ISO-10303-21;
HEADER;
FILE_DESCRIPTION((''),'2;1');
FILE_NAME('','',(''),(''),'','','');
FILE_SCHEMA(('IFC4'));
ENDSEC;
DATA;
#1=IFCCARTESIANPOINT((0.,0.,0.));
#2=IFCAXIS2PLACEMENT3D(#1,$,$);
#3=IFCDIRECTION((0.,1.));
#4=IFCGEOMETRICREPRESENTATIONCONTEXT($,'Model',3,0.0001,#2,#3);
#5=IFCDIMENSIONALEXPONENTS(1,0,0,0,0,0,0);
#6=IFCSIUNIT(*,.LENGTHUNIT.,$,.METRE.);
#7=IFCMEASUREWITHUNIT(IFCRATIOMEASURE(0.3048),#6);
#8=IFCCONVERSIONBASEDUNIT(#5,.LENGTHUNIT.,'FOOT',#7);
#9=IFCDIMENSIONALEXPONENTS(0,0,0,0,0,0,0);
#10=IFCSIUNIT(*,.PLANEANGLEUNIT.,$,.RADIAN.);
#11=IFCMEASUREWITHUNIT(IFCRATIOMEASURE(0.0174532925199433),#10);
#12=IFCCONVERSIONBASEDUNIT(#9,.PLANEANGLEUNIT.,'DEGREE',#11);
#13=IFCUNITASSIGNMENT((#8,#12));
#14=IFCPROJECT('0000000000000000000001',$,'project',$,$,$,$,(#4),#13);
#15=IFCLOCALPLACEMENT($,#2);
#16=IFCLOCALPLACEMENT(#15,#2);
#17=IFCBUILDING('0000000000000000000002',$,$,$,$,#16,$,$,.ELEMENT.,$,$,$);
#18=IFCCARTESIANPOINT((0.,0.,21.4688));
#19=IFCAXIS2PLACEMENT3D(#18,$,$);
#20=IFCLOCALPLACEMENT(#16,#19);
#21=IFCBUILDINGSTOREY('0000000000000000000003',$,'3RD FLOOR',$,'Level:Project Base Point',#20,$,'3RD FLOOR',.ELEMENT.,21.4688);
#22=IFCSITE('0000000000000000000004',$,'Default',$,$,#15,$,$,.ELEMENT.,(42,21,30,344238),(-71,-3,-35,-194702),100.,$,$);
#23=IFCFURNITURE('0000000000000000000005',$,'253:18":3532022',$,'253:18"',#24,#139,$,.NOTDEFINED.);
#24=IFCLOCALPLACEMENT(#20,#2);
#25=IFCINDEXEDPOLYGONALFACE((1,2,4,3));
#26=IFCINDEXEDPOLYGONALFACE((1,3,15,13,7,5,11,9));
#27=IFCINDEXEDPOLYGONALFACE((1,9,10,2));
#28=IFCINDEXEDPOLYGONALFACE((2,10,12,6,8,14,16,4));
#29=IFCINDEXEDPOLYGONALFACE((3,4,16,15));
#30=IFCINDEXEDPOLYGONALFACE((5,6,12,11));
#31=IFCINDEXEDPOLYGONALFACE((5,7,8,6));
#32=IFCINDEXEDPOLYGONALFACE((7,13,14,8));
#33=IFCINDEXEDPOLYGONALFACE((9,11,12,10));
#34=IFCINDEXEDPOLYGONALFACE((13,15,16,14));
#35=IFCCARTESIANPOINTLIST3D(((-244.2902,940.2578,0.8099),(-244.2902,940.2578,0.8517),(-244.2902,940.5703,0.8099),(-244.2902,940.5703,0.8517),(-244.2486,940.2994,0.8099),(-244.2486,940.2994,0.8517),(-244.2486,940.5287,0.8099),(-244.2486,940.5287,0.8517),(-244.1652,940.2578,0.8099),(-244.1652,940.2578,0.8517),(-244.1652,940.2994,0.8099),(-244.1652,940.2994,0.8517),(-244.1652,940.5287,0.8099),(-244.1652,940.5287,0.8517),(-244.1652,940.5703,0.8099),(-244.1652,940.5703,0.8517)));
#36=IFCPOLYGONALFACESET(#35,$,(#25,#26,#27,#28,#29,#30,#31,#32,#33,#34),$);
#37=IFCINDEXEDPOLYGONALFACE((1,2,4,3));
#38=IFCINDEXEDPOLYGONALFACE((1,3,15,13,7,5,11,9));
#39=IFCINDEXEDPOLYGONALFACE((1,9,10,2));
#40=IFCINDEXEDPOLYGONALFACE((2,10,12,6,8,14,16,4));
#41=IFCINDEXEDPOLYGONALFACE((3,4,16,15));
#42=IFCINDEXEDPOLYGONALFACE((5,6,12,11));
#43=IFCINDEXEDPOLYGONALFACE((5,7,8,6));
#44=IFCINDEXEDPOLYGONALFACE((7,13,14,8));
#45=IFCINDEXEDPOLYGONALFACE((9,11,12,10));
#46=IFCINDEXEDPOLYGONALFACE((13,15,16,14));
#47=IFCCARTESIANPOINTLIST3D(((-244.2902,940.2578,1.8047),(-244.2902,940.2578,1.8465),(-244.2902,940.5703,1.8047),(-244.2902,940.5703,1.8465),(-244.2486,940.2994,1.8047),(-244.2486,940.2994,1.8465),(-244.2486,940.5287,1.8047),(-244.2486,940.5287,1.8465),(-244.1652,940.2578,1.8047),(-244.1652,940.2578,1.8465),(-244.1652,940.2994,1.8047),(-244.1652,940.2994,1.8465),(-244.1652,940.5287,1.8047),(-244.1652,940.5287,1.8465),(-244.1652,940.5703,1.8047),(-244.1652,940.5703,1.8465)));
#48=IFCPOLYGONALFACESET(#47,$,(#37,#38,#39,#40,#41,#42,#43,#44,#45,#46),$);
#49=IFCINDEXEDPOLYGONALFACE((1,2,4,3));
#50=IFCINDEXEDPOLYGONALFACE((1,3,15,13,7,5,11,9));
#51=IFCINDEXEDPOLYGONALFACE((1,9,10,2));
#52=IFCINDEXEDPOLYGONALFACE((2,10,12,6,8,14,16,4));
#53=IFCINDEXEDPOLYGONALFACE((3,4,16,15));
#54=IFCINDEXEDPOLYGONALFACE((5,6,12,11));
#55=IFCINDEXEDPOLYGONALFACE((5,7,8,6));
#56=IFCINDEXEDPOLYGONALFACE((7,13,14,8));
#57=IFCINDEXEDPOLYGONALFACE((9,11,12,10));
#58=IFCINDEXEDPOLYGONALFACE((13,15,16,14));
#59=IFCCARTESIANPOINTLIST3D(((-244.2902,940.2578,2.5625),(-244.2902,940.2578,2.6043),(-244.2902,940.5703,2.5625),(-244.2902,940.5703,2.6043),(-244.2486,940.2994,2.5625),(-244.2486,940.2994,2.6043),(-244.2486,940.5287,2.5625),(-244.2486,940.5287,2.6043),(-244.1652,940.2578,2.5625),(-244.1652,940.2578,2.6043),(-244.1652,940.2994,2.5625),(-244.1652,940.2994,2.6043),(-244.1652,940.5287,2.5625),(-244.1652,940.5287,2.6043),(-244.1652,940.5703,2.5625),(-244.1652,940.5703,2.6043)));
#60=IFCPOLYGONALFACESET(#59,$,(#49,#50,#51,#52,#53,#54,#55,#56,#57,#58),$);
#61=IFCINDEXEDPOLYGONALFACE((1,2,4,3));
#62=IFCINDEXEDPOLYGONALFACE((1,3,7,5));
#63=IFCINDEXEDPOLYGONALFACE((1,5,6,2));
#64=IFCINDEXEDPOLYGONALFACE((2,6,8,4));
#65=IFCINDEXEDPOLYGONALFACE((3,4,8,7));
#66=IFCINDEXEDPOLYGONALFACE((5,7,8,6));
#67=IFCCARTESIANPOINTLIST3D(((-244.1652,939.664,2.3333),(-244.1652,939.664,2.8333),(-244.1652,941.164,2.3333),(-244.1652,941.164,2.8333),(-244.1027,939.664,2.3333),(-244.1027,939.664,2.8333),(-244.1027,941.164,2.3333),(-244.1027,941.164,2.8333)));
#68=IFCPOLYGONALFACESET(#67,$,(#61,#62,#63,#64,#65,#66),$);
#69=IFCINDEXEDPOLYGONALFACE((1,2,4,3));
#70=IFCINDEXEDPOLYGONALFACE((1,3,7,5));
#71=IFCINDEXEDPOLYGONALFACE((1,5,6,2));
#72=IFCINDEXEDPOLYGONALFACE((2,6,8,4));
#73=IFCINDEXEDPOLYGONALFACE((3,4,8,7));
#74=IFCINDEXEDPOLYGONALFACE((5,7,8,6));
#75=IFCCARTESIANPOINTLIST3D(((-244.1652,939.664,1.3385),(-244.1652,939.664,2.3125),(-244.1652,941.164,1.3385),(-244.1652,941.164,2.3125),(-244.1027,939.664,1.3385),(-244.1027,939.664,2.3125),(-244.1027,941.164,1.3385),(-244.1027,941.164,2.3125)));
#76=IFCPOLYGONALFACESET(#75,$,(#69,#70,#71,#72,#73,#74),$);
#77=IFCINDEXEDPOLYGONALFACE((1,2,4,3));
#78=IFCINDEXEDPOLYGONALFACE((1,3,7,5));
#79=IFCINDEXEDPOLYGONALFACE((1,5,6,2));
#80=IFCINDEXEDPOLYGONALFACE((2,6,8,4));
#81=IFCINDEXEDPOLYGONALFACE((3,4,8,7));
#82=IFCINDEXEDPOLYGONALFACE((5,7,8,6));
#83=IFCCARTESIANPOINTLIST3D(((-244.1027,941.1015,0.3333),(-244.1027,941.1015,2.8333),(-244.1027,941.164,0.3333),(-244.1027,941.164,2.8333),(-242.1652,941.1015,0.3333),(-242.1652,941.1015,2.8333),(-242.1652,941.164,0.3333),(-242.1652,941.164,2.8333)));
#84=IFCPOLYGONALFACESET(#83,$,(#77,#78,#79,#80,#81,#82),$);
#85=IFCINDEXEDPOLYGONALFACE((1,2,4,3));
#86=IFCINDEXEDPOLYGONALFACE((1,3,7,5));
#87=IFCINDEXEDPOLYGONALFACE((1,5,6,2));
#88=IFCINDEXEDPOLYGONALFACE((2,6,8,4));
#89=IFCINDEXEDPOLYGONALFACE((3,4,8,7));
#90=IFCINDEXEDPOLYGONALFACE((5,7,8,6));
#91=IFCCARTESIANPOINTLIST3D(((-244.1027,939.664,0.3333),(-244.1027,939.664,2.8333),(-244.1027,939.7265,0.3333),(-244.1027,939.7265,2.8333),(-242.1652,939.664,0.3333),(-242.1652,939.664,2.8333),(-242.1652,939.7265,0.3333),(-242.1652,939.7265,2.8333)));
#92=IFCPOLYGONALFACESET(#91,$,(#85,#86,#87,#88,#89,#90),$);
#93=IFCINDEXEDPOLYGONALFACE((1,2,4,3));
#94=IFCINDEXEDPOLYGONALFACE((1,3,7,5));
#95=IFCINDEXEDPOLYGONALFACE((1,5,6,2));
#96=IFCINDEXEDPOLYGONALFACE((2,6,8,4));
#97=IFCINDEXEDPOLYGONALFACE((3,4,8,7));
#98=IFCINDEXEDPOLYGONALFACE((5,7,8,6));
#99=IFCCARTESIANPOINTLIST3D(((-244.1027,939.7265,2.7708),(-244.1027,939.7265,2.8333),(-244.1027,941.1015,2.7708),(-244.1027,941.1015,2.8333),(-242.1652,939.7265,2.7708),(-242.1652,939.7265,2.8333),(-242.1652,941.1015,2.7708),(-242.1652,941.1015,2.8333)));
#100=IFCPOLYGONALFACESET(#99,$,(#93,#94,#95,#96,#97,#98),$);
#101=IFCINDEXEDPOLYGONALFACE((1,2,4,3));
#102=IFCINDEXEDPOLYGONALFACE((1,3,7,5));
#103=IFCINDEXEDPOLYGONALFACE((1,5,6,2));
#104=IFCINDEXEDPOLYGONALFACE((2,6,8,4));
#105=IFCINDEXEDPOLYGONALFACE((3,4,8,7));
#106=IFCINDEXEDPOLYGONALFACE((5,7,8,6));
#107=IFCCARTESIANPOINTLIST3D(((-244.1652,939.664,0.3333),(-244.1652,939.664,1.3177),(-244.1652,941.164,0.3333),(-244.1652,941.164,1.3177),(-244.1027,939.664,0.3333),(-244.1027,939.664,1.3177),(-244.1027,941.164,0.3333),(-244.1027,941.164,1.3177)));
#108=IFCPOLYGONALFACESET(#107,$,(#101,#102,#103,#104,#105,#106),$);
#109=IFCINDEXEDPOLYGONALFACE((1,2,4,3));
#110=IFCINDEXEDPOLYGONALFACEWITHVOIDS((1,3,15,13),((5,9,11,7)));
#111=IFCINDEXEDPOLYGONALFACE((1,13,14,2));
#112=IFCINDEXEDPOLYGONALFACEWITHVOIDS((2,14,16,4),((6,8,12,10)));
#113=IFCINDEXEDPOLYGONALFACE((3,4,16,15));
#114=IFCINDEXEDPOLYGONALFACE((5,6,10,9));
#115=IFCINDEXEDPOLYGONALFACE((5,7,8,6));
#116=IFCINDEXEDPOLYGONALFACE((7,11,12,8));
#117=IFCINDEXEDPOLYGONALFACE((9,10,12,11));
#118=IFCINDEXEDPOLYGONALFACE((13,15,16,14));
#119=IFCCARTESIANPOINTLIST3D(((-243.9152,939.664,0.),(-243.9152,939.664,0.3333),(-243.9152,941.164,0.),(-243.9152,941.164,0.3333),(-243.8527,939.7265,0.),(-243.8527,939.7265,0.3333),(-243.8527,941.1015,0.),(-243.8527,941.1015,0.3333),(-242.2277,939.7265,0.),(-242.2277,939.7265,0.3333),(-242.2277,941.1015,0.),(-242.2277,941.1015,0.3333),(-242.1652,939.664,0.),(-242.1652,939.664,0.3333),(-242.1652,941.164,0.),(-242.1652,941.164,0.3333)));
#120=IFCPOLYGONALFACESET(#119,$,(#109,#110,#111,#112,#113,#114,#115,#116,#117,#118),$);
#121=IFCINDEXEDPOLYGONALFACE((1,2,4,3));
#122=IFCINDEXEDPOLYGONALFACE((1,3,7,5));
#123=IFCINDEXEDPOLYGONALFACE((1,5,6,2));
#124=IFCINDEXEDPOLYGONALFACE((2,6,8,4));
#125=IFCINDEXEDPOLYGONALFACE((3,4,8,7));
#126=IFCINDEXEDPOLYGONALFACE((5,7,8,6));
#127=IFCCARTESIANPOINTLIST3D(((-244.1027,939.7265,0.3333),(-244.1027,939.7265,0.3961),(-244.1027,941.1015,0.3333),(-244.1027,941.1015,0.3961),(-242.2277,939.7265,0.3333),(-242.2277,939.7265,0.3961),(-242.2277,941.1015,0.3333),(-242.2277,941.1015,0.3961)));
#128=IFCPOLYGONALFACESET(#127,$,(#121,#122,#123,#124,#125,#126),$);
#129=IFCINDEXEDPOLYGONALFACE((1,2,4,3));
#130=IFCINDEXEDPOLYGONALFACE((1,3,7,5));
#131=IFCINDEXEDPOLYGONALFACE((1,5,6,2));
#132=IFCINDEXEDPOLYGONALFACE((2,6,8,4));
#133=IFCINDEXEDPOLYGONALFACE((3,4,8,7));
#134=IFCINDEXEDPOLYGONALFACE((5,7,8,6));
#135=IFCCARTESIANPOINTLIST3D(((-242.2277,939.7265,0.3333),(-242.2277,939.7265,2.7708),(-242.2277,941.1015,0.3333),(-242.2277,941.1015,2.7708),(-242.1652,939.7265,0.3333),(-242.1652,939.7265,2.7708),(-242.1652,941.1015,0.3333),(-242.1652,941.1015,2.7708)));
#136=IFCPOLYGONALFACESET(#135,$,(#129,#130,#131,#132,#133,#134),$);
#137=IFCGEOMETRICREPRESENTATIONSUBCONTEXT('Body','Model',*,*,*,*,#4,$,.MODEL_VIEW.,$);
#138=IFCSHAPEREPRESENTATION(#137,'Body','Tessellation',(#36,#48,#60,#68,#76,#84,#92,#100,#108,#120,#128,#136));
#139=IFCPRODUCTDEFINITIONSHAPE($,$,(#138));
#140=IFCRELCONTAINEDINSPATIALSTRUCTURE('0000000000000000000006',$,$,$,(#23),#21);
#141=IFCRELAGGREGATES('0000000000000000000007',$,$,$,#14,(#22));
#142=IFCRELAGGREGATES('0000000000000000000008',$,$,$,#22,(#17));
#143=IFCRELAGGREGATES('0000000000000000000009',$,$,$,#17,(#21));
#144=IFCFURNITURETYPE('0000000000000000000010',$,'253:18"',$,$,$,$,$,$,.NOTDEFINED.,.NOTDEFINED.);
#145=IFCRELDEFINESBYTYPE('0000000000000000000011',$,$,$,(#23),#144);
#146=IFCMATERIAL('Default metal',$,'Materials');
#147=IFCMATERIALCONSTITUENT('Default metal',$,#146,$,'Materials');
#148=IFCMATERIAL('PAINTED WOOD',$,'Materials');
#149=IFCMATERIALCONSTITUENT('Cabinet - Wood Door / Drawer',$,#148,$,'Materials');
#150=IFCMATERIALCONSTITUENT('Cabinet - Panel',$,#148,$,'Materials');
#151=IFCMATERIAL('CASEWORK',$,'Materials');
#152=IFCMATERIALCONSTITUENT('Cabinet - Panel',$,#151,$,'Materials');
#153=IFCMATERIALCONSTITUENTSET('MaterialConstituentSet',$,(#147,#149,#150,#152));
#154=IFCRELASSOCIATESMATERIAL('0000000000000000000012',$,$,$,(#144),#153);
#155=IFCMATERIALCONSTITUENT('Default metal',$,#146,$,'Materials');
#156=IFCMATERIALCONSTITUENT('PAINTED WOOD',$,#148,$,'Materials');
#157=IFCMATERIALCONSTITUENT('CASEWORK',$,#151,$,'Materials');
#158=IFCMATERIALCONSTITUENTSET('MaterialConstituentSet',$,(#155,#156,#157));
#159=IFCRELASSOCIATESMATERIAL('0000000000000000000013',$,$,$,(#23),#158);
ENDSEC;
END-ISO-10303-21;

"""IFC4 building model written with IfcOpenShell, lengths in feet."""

from ifc_helpers import new_model, entity, si_unit, converted_unit, direction, frame, frame_2d, origin, origin_2d_with_axis, place, context, subcontext, project, spatial, polyline, rectangle, outline, extrude, source, transform, mapped, material, constituent, constituent_set, type_object, type_shapes, element, save


model = new_model("IFC4")

# Units and contexts
model_context = context("Model", 3, precision=0.0001, world=origin(), true_north=direction((0.0, 1.0)))
body_context = subcontext(model_context, "Body", "Model", "MODEL_VIEW")
ifc_project = project(units=[converted_unit("LENGTHUNIT", "FOOT", entity("IfcRatioMeasure", 0.3048), si_unit("LENGTHUNIT", "METRE"), dimensions=[1, 0, 0, 0, 0, 0, 0]), converted_unit("PLANEANGLEUNIT", "DEGREE", entity("IfcRatioMeasure", 0.0174532925199433), si_unit("PLANEANGLEUNIT", "RADIAN"), dimensions=[0, 0, 0, 0, 0, 0, 0])], contexts=[model_context])

# Site, building, storey
site_placement = place(None, origin())
site = spatial("IfcSite", under=ifc_project, at=site_placement, Name="Default", CompositionType="ELEMENT", RefLatitude=(42, 21, 30, 344238), RefLongitude=(-71, -3, -35, -194702), RefElevation=100.0)
building_placement = place(site_placement, origin())
building = spatial("IfcBuilding", under=site, at=building_placement, CompositionType="ELEMENT")
storey_placement = place(building_placement, frame((0.0, 0.0, 21.4688)))
storey = spatial("IfcBuildingStorey", under=building, at=storey_placement, Name="3RD FLOOR", ObjectType="Level:Project Base Point", LongName="3RD FLOOR", CompositionType="ELEMENT", Elevation=21.4688)

# Furniture
ifc_material_1 = material(Name="CASEWORK", Category="Materials")
ifc_material_2 = material(Name="PAINTED WOOD", Category="Materials")
ifc_material_3 = material(Name="Default metal", Category="Materials")
ifc_constituent_1 = constituent(ifc_material_3, Name="Default metal", Category="Materials")
ifc_constituent_2 = constituent(ifc_material_2, Name="PAINTED WOOD", Category="Materials")
ifc_constituent_3 = constituent(ifc_material_1, Name="CASEWORK", Category="Materials")
ifc_constituent_set_1 = constituent_set(constituents=[ifc_constituent_1, ifc_constituent_2, ifc_constituent_3], Name="MaterialConstituentSet")
ifc_constituent_4 = constituent(ifc_material_3, Name="Default metal", Category="Materials")
ifc_constituent_5 = constituent(ifc_material_2, Name="Cabinet - Wood Door / Drawer", Category="Materials")
ifc_constituent_6 = constituent(ifc_material_2, Name="Cabinet - Panel", Category="Materials")
ifc_constituent_7 = constituent(ifc_material_1, Name="Cabinet - Panel", Category="Materials")
ifc_constituent_set_2 = constituent_set(constituents=[ifc_constituent_4, ifc_constituent_5, ifc_constituent_6, ifc_constituent_7], Name="MaterialConstituentSet")
furniture_type_1 = type_object("IfcFurnitureType", Name="253:18\"", AssemblyPlace="NOTDEFINED", PredefinedType="NOTDEFINED", material=ifc_constituent_set_2)
shared_shape_1 = source(origin(), body_context, "Body", "SweptSolid", [
    extrude(outline(polyline([(-0.0521, -0.1562), (0.0729, -0.1562), (0.0729, 0.1562), (-0.0521, 0.1562), (-0.0521, 0.1146), (0.0313, 0.1146), (0.0313, -0.1146), (-0.0521, -0.1146), (-0.0521, -0.1562)])), frame((0.0615, -2.0521, 0.8099), z_axis=(0.0, 0.0, 1.0), x_axis=(0.0, -1.0, 0.0)), (0.0, 0.0, 1.0), 0.0418),
    extrude(outline(polyline([(-0.0521, -0.1562), (0.0729, -0.1562), (0.0729, 0.1562), (-0.0521, 0.1562), (-0.0521, 0.1146), (0.0313, 0.1146), (0.0313, -0.1146), (-0.0521, -0.1146), (-0.0521, -0.1562)])), frame((0.0615, -2.0521, 1.8047), z_axis=(0.0, 0.0, 1.0), x_axis=(0.0, -1.0, 0.0)), (0.0, 0.0, 1.0), 0.0418),
    extrude(outline(polyline([(-0.0521, -0.1562), (0.0729, -0.1562), (0.0729, 0.1562), (-0.0521, 0.1562), (-0.0521, 0.1146), (0.0313, 0.1146), (0.0313, -0.1146), (-0.0521, -0.1146), (-0.0521, -0.1562)])), frame((0.0615, -2.0521, 2.5625), z_axis=(0.0, 0.0, 1.0), x_axis=(0.0, -1.0, 0.0)), (0.0, 0.0, 1.0), 0.0418),
    extrude(rectangle(XDim=0.0625, YDim=1.5, at=frame_2d((0.0, 0.0), x_axis=(1.0, 0.0))), frame((0.0615, -1.9688, 2.3333), z_axis=(0.0, 0.0, 1.0), x_axis=(0.0, 1.0, 0.0)), (0.0, 0.0, 1.0), 0.5),
    extrude(rectangle(XDim=0.0625, YDim=1.5, at=frame_2d((0.0, 0.0), x_axis=(1.0, 0.0))), frame((0.0615, -1.9688, 1.3385), z_axis=(0.0, 0.0, 1.0), x_axis=(0.0, 1.0, 0.0)), (0.0, 0.0, 1.0), 0.974),
    extrude(rectangle(XDim=0.0625, YDim=1.9375, at=frame_2d((0.0, 0.0), x_axis=(1.0, 0.0))), frame((-0.6573, -0.9687, 0.3333)), (0.0, 0.0, 1.0), 2.5),
    extrude(rectangle(XDim=0.0625, YDim=1.9375, at=frame_2d((0.0, 0.0), x_axis=(1.0, 0.0))), frame((0.7802, -0.9687, 0.3333)), (0.0, 0.0, 1.0), 2.5),
    extrude(rectangle(XDim=1.375, YDim=1.9375, at=origin_2d_with_axis()), frame((0.0615, -0.9688, 2.7708), z_axis=(0.0, 0.0, 1.0), x_axis=(-1.0, 0.0, 0.0)), (0.0, 0.0, 1.0), 0.0625),
    extrude(rectangle(XDim=0.0625, YDim=1.5, at=frame_2d((0.0, 0.0), x_axis=(1.0, 0.0))), frame((0.0615, -1.9688, 0.3333), z_axis=(0.0, 0.0, 1.0), x_axis=(0.0, 1.0, 0.0)), (0.0, 0.0, 1.0), 0.9844),
    extrude(outline(polyline([(-0.75, -0.875), (0.75, -0.875), (0.75, 0.875), (-0.75, 0.875), (-0.75, -0.875)]), holes=[polyline([(-0.6875, -0.8125), (-0.6875, 0.8125), (0.6875, 0.8125), (0.6875, -0.8125), (-0.6875, -0.8125)])]), frame((0.0615, -0.875, 0.0)), (0.0, 0.0, 1.0), 0.3333),
    extrude(rectangle(XDim=1.375, YDim=1.875, at=frame_2d((0.0, 0.0), x_axis=(1.0, 0.0))), frame((0.0615, -1.0, 0.3333), z_axis=(0.0, 0.0, 1.0), x_axis=(-1.0, 0.0, 0.0)), (0.0, 0.0, 1.0), 0.0627),
    extrude(rectangle(XDim=0.0625, YDim=1.375, at=origin_2d_with_axis()), frame((0.0615, -0.0312, 0.3333), z_axis=(0.0, 0.0, 1.0), x_axis=(0.0, 1.0, 0.0)), (0.0, 0.0, 1.0), 2.4375),
])
type_shapes(furniture_type_1, [shared_shape_1])
furniture_1_placement = place(storey_placement, frame((-242.1652, 940.4755, 0.0), z_axis=(0.0, 0.0, 1.0), x_axis=(0.0, -1.0, 0.0)))
element("IfcFurniture", 1, at=furniture_1_placement, inside=storey, type_object=furniture_type_1, material=ifc_constituent_set_1, Name="253:18\":3532022", ObjectType="253:18\"", PredefinedType="NOTDEFINED", context=body_context, shape_type="MappedRepresentation", body=[
    mapped(shared_shape_1, transform((0.0, 0.0, 0.0), scale=1.0)),
])

save(model, "model.ifc")
